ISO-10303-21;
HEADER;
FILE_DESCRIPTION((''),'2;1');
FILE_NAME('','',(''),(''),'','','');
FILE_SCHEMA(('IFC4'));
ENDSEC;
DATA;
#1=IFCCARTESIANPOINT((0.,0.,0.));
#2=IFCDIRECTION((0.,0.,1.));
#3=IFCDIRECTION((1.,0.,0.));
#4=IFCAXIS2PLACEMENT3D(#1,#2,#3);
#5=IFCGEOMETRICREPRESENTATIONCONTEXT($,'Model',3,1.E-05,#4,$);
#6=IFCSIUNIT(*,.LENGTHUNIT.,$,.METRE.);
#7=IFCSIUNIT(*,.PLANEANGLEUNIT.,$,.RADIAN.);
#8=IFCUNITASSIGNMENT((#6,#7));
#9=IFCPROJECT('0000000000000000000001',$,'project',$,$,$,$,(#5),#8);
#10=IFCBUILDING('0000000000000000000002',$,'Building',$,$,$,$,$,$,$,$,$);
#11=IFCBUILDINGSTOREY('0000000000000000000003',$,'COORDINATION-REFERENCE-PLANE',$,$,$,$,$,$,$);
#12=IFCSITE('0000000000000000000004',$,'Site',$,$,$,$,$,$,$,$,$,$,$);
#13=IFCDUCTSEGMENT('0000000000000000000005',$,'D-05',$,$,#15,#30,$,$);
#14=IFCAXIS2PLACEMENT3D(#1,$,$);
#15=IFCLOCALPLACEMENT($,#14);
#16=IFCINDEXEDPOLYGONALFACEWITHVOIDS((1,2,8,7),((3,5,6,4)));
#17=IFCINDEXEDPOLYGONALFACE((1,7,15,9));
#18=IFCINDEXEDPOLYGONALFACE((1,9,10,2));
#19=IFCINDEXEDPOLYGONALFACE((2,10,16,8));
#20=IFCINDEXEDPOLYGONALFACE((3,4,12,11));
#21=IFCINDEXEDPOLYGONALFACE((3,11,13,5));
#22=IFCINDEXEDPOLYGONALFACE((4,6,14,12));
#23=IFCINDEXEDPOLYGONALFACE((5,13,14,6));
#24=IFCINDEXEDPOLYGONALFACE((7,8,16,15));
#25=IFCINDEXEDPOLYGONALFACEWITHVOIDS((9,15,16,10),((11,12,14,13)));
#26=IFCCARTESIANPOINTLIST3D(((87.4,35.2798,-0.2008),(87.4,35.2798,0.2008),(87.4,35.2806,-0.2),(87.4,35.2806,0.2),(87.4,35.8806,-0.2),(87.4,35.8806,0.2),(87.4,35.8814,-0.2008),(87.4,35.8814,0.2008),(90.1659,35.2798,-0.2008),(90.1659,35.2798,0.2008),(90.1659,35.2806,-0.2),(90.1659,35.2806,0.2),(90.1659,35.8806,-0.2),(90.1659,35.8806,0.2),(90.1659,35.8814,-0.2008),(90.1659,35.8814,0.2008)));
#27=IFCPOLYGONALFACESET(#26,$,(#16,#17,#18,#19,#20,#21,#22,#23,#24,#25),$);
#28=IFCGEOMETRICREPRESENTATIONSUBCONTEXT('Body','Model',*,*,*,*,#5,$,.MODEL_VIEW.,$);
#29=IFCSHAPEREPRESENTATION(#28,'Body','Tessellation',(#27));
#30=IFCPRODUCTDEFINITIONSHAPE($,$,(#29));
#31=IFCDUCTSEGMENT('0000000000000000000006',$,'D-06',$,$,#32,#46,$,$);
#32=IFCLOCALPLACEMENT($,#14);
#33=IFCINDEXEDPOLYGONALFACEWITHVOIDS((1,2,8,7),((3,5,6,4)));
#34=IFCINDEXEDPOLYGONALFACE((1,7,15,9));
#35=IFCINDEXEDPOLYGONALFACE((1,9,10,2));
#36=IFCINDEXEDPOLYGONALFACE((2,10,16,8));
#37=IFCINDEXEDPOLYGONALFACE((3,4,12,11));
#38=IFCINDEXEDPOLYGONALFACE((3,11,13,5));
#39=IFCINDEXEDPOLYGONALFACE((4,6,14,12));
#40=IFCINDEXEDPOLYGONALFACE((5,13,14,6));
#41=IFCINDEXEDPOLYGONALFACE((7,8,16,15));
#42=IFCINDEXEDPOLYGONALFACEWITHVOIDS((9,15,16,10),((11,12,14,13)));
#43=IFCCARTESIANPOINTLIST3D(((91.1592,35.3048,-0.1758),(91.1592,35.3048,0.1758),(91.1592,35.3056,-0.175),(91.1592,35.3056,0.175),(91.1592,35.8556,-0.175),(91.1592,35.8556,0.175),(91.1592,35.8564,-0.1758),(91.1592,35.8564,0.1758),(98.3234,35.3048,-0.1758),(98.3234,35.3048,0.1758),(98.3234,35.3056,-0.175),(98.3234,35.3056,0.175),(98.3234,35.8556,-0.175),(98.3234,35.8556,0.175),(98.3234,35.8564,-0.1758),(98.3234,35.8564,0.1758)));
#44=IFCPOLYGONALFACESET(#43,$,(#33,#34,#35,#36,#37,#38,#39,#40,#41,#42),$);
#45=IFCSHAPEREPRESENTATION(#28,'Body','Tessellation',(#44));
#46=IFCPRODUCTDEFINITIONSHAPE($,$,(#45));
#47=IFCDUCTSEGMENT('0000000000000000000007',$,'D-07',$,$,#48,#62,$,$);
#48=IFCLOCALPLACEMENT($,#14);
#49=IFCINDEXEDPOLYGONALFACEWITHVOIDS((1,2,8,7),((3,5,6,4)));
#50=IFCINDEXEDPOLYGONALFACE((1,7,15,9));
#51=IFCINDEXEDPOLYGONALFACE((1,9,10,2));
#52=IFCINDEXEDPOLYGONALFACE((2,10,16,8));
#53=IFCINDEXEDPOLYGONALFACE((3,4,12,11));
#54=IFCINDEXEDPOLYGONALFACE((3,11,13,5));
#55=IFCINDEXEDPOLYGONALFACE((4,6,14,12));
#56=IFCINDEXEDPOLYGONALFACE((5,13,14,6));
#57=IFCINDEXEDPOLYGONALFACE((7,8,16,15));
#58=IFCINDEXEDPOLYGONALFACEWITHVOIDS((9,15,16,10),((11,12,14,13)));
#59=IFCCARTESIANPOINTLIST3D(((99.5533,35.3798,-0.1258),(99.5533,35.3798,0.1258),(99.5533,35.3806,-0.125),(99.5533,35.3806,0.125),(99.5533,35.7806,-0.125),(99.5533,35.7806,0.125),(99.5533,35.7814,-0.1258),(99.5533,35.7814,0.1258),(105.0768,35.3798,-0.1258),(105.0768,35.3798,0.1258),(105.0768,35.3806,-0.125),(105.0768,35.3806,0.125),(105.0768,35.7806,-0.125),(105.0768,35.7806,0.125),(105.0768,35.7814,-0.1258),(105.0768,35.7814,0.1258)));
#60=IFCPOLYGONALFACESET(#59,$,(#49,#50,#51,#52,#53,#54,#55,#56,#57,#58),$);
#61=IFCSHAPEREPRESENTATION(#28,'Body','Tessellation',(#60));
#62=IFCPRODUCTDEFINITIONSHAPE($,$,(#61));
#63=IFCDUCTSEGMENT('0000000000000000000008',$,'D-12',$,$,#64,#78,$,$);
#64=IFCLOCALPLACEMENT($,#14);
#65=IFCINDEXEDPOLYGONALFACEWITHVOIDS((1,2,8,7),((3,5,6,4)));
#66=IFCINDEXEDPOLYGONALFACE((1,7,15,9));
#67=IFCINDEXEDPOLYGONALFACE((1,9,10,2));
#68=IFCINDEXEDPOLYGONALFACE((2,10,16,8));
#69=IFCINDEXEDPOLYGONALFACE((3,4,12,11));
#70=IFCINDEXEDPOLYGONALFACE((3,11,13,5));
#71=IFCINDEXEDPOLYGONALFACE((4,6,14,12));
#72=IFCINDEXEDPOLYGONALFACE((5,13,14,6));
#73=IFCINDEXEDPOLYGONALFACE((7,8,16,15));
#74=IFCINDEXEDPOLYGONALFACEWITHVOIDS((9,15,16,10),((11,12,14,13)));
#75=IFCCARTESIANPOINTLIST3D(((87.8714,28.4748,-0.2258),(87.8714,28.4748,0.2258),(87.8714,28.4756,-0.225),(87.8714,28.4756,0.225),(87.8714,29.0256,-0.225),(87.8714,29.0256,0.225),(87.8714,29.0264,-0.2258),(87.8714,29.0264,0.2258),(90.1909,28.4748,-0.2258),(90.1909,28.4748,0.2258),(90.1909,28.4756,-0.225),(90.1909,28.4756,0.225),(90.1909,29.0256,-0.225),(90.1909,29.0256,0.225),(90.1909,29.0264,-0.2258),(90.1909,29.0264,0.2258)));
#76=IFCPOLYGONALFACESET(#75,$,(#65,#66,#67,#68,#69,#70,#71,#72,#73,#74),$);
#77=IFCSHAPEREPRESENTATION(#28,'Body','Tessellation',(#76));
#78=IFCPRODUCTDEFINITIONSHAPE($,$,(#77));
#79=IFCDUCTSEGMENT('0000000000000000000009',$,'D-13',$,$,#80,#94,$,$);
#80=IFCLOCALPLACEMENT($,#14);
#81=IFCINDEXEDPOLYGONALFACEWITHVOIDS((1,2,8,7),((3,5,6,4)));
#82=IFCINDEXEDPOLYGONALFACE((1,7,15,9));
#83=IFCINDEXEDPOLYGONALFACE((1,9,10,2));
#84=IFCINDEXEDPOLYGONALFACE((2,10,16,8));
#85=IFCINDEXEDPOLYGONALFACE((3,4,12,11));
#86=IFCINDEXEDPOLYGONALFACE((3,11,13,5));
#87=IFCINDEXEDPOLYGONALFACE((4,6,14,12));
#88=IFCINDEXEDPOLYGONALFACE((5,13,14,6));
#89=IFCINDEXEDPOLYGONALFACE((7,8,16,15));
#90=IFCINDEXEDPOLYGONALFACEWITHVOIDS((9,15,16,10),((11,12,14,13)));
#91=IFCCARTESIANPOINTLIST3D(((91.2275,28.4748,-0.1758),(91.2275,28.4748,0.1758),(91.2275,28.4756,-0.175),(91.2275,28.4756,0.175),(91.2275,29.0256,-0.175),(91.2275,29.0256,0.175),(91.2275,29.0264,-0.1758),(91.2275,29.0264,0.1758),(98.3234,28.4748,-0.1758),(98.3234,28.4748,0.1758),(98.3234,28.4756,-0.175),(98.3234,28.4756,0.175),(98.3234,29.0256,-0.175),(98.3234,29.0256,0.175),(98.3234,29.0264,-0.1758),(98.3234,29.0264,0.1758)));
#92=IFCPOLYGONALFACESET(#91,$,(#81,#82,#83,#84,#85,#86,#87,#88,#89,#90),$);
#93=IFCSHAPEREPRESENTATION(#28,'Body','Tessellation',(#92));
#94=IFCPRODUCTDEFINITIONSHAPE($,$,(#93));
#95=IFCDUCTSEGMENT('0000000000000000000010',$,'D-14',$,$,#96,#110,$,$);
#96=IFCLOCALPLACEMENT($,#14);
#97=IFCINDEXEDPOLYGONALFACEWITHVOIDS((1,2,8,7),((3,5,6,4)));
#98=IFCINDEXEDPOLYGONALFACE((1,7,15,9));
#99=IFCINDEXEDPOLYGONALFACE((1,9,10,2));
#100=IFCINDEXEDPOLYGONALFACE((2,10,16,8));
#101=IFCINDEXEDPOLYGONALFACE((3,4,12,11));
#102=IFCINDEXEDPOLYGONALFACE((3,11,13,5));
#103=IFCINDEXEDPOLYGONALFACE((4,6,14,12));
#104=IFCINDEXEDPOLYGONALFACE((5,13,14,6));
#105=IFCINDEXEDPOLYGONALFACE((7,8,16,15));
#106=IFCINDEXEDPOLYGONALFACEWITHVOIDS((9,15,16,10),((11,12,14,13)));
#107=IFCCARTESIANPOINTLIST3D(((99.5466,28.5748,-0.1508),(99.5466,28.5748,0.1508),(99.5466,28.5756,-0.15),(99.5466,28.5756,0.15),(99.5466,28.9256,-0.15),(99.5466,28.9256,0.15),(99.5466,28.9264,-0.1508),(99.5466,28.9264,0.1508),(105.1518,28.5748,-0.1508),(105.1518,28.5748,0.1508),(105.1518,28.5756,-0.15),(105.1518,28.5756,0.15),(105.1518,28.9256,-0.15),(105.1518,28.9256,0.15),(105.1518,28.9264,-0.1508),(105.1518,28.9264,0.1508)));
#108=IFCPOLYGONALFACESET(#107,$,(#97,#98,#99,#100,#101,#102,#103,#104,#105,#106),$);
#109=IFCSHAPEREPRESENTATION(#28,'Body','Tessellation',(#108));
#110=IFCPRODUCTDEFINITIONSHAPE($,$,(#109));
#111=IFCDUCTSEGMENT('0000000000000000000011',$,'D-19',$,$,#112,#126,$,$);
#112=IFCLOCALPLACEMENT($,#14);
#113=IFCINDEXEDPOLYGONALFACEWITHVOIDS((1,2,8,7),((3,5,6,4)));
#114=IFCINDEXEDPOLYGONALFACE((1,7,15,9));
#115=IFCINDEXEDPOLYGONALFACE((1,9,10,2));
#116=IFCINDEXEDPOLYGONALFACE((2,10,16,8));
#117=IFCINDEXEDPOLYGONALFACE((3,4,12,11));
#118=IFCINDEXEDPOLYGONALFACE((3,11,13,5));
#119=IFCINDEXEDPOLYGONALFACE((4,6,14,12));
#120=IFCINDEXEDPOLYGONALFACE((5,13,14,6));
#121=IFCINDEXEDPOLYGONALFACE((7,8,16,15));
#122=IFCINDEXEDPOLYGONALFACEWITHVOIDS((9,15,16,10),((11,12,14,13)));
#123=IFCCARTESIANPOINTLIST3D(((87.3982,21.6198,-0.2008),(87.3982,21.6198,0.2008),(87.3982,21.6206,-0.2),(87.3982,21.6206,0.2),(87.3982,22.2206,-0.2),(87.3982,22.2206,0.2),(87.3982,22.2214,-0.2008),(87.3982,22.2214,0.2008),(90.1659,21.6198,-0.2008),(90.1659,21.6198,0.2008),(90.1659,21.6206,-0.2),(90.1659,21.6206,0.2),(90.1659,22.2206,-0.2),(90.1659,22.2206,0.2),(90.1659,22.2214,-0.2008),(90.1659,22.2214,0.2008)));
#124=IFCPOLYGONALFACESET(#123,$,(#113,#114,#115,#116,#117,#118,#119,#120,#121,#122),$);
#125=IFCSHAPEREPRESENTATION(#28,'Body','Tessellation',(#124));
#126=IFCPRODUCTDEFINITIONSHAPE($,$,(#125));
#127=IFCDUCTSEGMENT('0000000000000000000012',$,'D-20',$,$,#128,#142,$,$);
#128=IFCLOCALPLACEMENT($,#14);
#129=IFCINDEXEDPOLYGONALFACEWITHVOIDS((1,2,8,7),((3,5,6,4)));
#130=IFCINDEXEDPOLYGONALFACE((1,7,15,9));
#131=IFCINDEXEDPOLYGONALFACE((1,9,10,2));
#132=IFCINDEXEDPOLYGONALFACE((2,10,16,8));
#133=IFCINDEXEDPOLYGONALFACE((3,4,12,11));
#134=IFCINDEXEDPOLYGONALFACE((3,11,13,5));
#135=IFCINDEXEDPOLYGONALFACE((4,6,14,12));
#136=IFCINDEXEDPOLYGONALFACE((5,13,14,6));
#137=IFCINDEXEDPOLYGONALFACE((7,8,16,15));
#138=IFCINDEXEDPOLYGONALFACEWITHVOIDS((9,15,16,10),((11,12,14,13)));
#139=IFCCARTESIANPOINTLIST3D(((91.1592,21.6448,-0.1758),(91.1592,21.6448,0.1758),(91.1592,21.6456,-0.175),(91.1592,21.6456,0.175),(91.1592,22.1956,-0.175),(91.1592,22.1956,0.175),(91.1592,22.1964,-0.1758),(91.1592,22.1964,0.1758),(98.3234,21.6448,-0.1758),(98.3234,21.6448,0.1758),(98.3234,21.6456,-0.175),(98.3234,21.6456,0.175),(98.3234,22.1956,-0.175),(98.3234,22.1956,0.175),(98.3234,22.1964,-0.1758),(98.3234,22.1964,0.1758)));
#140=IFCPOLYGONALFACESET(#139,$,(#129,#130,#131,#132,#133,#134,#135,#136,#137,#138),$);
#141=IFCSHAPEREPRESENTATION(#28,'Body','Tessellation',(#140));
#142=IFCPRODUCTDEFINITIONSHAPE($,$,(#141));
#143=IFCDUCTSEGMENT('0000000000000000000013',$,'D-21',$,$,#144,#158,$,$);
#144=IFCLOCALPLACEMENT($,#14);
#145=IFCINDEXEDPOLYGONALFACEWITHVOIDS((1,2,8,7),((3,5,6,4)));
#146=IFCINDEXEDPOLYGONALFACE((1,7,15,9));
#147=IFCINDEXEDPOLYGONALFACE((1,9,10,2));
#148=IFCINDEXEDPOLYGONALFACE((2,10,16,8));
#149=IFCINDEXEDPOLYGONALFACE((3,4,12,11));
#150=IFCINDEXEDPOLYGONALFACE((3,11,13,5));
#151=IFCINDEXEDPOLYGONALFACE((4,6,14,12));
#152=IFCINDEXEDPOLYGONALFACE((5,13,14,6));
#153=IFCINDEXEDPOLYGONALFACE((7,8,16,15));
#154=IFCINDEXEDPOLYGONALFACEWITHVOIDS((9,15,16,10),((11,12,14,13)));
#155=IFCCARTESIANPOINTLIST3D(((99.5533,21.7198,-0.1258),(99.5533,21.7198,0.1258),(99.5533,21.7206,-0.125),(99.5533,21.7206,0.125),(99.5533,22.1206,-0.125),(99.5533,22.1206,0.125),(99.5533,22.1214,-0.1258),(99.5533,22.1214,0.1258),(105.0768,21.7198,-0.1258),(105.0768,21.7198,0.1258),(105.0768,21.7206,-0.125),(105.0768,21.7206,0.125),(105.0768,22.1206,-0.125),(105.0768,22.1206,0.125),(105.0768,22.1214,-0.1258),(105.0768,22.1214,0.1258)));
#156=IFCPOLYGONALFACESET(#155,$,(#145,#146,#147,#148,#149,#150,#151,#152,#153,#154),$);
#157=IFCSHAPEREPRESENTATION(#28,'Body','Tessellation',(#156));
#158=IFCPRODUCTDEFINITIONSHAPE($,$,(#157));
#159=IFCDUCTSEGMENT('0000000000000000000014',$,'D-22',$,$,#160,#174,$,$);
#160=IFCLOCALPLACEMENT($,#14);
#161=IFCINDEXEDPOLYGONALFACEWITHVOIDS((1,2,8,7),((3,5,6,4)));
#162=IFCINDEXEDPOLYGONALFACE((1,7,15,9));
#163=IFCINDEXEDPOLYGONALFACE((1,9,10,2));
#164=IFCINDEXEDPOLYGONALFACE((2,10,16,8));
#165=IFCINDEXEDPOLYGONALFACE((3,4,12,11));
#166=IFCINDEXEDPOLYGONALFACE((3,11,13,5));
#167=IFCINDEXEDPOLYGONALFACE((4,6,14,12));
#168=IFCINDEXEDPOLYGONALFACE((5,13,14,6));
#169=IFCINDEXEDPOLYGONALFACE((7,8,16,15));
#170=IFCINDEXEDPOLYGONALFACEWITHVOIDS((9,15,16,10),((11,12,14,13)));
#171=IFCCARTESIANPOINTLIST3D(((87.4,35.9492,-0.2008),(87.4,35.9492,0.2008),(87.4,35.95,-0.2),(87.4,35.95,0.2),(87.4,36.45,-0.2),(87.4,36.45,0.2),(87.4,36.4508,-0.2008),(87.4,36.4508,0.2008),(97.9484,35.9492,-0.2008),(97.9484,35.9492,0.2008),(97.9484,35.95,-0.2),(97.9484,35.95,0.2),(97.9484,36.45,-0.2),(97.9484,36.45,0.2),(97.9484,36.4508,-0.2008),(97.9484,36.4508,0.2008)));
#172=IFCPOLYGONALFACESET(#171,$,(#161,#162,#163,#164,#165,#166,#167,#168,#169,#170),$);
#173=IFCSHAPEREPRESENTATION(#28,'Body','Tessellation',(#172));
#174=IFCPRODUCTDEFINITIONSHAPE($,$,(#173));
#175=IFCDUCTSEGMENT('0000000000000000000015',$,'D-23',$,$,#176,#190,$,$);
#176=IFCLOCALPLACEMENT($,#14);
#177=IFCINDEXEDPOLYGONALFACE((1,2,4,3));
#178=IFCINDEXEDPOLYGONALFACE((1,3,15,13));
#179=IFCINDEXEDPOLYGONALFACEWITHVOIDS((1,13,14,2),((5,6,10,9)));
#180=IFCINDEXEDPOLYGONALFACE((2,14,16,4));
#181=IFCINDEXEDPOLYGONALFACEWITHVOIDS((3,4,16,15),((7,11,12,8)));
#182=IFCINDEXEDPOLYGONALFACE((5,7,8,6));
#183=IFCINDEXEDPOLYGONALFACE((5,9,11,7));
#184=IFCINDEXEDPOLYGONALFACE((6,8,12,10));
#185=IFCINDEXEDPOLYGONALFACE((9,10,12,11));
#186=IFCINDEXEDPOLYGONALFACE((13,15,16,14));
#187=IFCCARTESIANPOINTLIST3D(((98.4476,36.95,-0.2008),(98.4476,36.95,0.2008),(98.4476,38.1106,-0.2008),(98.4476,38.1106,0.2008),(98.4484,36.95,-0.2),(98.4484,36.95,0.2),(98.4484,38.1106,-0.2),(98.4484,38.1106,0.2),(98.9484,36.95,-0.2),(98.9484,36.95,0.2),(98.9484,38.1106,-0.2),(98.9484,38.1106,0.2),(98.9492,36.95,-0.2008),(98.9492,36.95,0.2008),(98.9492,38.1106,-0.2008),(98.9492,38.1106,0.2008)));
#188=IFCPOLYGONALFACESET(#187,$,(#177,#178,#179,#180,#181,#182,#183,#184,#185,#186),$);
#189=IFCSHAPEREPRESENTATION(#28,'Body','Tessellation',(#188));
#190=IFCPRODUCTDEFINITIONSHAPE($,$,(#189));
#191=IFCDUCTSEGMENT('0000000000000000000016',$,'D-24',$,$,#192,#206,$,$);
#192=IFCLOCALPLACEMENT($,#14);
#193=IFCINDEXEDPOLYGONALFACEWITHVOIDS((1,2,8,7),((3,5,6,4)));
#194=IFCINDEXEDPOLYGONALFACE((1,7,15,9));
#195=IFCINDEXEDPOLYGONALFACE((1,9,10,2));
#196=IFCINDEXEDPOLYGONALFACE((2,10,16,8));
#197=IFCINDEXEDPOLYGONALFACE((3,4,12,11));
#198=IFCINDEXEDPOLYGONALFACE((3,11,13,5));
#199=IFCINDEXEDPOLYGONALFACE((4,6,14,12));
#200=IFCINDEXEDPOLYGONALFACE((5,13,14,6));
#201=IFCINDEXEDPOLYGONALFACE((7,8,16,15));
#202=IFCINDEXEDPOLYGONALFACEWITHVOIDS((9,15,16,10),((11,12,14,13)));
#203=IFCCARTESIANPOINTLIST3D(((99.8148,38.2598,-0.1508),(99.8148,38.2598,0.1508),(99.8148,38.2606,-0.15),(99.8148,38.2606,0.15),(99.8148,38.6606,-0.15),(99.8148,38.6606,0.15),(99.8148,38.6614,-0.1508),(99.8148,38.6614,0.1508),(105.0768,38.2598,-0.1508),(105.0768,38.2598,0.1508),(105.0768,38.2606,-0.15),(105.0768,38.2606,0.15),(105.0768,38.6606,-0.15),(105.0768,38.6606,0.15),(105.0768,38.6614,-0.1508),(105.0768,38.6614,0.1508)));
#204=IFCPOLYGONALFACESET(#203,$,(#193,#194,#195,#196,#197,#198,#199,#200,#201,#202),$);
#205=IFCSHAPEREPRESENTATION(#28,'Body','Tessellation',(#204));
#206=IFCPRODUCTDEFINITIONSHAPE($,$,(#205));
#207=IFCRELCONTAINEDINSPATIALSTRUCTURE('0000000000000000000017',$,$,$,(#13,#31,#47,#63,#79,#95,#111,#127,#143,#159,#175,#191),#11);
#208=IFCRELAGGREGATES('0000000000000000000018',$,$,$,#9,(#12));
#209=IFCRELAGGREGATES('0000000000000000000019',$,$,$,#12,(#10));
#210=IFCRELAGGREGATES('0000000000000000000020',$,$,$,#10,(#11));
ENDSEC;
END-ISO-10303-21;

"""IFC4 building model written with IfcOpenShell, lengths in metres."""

from ifc_helpers import new_model, si_unit, frame, origin, origin_with_axes, place, context, subcontext, project, spatial, hollow_rectangle, extrude, element, save


model = new_model("IFC4")

# Units and contexts
model_context = context("Model", 3, precision=1e-05, world=origin_with_axes())
body_context = subcontext(model_context, "Body", "Model", "MODEL_VIEW")
ifc_project = project(units=[si_unit("LENGTHUNIT", "METRE"), si_unit("PLANEANGLEUNIT", "RADIAN")], contexts=[model_context])

# Site, building, storey
site = spatial("IfcSite", under=ifc_project, Name="Site")
building = spatial("IfcBuilding", under=site, Name="Building")
storey = spatial("IfcBuildingStorey", under=building, Name="COORDINATION-REFERENCE-PLANE")

# Duct segments
duct_segment_1_placement = place(None, frame((87.4, 35.5806, 0.0), z_axis=(1.0, 0.0, 0.0), x_axis=(0.0, 1.0, 0.0)))
element("IfcDuctSegment", 1, at=duct_segment_1_placement, inside=storey, Name="D-05", context=body_context, shape_type="SweptSolid", body=[
    extrude(hollow_rectangle(XDim=0.6016, YDim=0.4016, WallThickness=0.0008), origin(), (0.0, 0.0, 1.0), 2.7659),
])
duct_segment_2_placement = place(None, frame((91.1592, 35.5806, 0.0), z_axis=(1.0, 0.0, 0.0), x_axis=(0.0, 1.0, 0.0)))
element("IfcDuctSegment", 2, at=duct_segment_2_placement, inside=storey, Name="D-06", context=body_context, shape_type="SweptSolid", body=[
    extrude(hollow_rectangle(XDim=0.5516, YDim=0.3516, WallThickness=0.0008), origin(), (0.0, 0.0, 1.0), 7.1642),
])
duct_segment_3_placement = place(None, frame((99.5533, 35.5806, 0.0), z_axis=(1.0, 0.0, 0.0), x_axis=(0.0, 1.0, 0.0)))
element("IfcDuctSegment", 3, at=duct_segment_3_placement, inside=storey, Name="D-07", context=body_context, shape_type="SweptSolid", body=[
    extrude(hollow_rectangle(XDim=0.4016, YDim=0.2516, WallThickness=0.0008), origin(), (0.0, 0.0, 1.0), 5.5234),
])
duct_segment_4_placement = place(None, frame((87.8714, 28.7506, 0.0), z_axis=(1.0, 0.0, 0.0), x_axis=(0.0, 1.0, 0.0)))
element("IfcDuctSegment", 4, at=duct_segment_4_placement, inside=storey, Name="D-12", context=body_context, shape_type="SweptSolid", body=[
    extrude(hollow_rectangle(XDim=0.5516, YDim=0.4516, WallThickness=0.0008), origin(), (0.0, 0.0, 1.0), 2.3195),
])
duct_segment_5_placement = place(None, frame((91.2275, 28.7506, 0.0), z_axis=(1.0, 0.0, 0.0), x_axis=(0.0, 1.0, 0.0)))
element("IfcDuctSegment", 5, at=duct_segment_5_placement, inside=storey, Name="D-13", context=body_context, shape_type="SweptSolid", body=[
    extrude(hollow_rectangle(XDim=0.5516, YDim=0.3516, WallThickness=0.0008), origin(), (0.0, 0.0, 1.0), 7.0959),
])
duct_segment_6_placement = place(None, frame((99.5466, 28.7506, 0.0), z_axis=(1.0, 0.0, 0.0), x_axis=(0.0, 1.0, 0.0)))
element("IfcDuctSegment", 6, at=duct_segment_6_placement, inside=storey, Name="D-14", context=body_context, shape_type="SweptSolid", body=[
    extrude(hollow_rectangle(XDim=0.3516, YDim=0.3016, WallThickness=0.0008), origin(), (0.0, 0.0, 1.0), 5.6051),
])
duct_segment_7_placement = place(None, frame((87.3982, 21.9206, 0.0), z_axis=(1.0, 0.0, 0.0), x_axis=(0.0, 1.0, 0.0)))
element("IfcDuctSegment", 7, at=duct_segment_7_placement, inside=storey, Name="D-19", context=body_context, shape_type="SweptSolid", body=[
    extrude(hollow_rectangle(XDim=0.6016, YDim=0.4016, WallThickness=0.0008), origin(), (0.0, 0.0, 1.0), 2.7677),
])
duct_segment_8_placement = place(None, frame((91.1592, 21.9206, 0.0), z_axis=(1.0, 0.0, 0.0), x_axis=(0.0, 1.0, 0.0)))
element("IfcDuctSegment", 8, at=duct_segment_8_placement, inside=storey, Name="D-20", context=body_context, shape_type="SweptSolid", body=[
    extrude(hollow_rectangle(XDim=0.5516, YDim=0.3516, WallThickness=0.0008), origin(), (0.0, 0.0, 1.0), 7.1642),
])
duct_segment_9_placement = place(None, frame((99.5533, 21.9206, 0.0), z_axis=(1.0, 0.0, 0.0), x_axis=(0.0, 1.0, 0.0)))
element("IfcDuctSegment", 9, at=duct_segment_9_placement, inside=storey, Name="D-21", context=body_context, shape_type="SweptSolid", body=[
    extrude(hollow_rectangle(XDim=0.4016, YDim=0.2516, WallThickness=0.0008), origin(), (0.0, 0.0, 1.0), 5.5234),
])
duct_segment_10_placement = place(None, frame((87.4, 36.2, 0.0), z_axis=(1.0, 0.0, 0.0), x_axis=(0.0, 1.0, 0.0)))
element("IfcDuctSegment", 10, at=duct_segment_10_placement, inside=storey, Name="D-22", context=body_context, shape_type="SweptSolid", body=[
    extrude(hollow_rectangle(XDim=0.5016, YDim=0.4016, WallThickness=0.0008), origin(), (0.0, 0.0, 1.0), 10.5484),
])
duct_segment_11_placement = place(None, frame((98.6984, 36.95, 0.0), z_axis=(0.0, 1.0, 0.0), x_axis=(1.0, 0.0, 0.0)))
element("IfcDuctSegment", 11, at=duct_segment_11_placement, inside=storey, Name="D-23", context=body_context, shape_type="SweptSolid", body=[
    extrude(hollow_rectangle(XDim=0.5016, YDim=0.4016, WallThickness=0.0008), origin(), (0.0, 0.0, 1.0), 1.1606),
])
duct_segment_12_placement = place(None, frame((99.8148, 38.4606, 0.0), z_axis=(1.0, 0.0, 0.0), x_axis=(0.0, 1.0, 0.0)))
element("IfcDuctSegment", 12, at=duct_segment_12_placement, inside=storey, Name="D-24", context=body_context, shape_type="SweptSolid", body=[
    extrude(hollow_rectangle(XDim=0.4016, YDim=0.3016, WallThickness=0.0008), origin(), (0.0, 0.0, 1.0), 5.2619),
])

save(model, "model.ifc")
